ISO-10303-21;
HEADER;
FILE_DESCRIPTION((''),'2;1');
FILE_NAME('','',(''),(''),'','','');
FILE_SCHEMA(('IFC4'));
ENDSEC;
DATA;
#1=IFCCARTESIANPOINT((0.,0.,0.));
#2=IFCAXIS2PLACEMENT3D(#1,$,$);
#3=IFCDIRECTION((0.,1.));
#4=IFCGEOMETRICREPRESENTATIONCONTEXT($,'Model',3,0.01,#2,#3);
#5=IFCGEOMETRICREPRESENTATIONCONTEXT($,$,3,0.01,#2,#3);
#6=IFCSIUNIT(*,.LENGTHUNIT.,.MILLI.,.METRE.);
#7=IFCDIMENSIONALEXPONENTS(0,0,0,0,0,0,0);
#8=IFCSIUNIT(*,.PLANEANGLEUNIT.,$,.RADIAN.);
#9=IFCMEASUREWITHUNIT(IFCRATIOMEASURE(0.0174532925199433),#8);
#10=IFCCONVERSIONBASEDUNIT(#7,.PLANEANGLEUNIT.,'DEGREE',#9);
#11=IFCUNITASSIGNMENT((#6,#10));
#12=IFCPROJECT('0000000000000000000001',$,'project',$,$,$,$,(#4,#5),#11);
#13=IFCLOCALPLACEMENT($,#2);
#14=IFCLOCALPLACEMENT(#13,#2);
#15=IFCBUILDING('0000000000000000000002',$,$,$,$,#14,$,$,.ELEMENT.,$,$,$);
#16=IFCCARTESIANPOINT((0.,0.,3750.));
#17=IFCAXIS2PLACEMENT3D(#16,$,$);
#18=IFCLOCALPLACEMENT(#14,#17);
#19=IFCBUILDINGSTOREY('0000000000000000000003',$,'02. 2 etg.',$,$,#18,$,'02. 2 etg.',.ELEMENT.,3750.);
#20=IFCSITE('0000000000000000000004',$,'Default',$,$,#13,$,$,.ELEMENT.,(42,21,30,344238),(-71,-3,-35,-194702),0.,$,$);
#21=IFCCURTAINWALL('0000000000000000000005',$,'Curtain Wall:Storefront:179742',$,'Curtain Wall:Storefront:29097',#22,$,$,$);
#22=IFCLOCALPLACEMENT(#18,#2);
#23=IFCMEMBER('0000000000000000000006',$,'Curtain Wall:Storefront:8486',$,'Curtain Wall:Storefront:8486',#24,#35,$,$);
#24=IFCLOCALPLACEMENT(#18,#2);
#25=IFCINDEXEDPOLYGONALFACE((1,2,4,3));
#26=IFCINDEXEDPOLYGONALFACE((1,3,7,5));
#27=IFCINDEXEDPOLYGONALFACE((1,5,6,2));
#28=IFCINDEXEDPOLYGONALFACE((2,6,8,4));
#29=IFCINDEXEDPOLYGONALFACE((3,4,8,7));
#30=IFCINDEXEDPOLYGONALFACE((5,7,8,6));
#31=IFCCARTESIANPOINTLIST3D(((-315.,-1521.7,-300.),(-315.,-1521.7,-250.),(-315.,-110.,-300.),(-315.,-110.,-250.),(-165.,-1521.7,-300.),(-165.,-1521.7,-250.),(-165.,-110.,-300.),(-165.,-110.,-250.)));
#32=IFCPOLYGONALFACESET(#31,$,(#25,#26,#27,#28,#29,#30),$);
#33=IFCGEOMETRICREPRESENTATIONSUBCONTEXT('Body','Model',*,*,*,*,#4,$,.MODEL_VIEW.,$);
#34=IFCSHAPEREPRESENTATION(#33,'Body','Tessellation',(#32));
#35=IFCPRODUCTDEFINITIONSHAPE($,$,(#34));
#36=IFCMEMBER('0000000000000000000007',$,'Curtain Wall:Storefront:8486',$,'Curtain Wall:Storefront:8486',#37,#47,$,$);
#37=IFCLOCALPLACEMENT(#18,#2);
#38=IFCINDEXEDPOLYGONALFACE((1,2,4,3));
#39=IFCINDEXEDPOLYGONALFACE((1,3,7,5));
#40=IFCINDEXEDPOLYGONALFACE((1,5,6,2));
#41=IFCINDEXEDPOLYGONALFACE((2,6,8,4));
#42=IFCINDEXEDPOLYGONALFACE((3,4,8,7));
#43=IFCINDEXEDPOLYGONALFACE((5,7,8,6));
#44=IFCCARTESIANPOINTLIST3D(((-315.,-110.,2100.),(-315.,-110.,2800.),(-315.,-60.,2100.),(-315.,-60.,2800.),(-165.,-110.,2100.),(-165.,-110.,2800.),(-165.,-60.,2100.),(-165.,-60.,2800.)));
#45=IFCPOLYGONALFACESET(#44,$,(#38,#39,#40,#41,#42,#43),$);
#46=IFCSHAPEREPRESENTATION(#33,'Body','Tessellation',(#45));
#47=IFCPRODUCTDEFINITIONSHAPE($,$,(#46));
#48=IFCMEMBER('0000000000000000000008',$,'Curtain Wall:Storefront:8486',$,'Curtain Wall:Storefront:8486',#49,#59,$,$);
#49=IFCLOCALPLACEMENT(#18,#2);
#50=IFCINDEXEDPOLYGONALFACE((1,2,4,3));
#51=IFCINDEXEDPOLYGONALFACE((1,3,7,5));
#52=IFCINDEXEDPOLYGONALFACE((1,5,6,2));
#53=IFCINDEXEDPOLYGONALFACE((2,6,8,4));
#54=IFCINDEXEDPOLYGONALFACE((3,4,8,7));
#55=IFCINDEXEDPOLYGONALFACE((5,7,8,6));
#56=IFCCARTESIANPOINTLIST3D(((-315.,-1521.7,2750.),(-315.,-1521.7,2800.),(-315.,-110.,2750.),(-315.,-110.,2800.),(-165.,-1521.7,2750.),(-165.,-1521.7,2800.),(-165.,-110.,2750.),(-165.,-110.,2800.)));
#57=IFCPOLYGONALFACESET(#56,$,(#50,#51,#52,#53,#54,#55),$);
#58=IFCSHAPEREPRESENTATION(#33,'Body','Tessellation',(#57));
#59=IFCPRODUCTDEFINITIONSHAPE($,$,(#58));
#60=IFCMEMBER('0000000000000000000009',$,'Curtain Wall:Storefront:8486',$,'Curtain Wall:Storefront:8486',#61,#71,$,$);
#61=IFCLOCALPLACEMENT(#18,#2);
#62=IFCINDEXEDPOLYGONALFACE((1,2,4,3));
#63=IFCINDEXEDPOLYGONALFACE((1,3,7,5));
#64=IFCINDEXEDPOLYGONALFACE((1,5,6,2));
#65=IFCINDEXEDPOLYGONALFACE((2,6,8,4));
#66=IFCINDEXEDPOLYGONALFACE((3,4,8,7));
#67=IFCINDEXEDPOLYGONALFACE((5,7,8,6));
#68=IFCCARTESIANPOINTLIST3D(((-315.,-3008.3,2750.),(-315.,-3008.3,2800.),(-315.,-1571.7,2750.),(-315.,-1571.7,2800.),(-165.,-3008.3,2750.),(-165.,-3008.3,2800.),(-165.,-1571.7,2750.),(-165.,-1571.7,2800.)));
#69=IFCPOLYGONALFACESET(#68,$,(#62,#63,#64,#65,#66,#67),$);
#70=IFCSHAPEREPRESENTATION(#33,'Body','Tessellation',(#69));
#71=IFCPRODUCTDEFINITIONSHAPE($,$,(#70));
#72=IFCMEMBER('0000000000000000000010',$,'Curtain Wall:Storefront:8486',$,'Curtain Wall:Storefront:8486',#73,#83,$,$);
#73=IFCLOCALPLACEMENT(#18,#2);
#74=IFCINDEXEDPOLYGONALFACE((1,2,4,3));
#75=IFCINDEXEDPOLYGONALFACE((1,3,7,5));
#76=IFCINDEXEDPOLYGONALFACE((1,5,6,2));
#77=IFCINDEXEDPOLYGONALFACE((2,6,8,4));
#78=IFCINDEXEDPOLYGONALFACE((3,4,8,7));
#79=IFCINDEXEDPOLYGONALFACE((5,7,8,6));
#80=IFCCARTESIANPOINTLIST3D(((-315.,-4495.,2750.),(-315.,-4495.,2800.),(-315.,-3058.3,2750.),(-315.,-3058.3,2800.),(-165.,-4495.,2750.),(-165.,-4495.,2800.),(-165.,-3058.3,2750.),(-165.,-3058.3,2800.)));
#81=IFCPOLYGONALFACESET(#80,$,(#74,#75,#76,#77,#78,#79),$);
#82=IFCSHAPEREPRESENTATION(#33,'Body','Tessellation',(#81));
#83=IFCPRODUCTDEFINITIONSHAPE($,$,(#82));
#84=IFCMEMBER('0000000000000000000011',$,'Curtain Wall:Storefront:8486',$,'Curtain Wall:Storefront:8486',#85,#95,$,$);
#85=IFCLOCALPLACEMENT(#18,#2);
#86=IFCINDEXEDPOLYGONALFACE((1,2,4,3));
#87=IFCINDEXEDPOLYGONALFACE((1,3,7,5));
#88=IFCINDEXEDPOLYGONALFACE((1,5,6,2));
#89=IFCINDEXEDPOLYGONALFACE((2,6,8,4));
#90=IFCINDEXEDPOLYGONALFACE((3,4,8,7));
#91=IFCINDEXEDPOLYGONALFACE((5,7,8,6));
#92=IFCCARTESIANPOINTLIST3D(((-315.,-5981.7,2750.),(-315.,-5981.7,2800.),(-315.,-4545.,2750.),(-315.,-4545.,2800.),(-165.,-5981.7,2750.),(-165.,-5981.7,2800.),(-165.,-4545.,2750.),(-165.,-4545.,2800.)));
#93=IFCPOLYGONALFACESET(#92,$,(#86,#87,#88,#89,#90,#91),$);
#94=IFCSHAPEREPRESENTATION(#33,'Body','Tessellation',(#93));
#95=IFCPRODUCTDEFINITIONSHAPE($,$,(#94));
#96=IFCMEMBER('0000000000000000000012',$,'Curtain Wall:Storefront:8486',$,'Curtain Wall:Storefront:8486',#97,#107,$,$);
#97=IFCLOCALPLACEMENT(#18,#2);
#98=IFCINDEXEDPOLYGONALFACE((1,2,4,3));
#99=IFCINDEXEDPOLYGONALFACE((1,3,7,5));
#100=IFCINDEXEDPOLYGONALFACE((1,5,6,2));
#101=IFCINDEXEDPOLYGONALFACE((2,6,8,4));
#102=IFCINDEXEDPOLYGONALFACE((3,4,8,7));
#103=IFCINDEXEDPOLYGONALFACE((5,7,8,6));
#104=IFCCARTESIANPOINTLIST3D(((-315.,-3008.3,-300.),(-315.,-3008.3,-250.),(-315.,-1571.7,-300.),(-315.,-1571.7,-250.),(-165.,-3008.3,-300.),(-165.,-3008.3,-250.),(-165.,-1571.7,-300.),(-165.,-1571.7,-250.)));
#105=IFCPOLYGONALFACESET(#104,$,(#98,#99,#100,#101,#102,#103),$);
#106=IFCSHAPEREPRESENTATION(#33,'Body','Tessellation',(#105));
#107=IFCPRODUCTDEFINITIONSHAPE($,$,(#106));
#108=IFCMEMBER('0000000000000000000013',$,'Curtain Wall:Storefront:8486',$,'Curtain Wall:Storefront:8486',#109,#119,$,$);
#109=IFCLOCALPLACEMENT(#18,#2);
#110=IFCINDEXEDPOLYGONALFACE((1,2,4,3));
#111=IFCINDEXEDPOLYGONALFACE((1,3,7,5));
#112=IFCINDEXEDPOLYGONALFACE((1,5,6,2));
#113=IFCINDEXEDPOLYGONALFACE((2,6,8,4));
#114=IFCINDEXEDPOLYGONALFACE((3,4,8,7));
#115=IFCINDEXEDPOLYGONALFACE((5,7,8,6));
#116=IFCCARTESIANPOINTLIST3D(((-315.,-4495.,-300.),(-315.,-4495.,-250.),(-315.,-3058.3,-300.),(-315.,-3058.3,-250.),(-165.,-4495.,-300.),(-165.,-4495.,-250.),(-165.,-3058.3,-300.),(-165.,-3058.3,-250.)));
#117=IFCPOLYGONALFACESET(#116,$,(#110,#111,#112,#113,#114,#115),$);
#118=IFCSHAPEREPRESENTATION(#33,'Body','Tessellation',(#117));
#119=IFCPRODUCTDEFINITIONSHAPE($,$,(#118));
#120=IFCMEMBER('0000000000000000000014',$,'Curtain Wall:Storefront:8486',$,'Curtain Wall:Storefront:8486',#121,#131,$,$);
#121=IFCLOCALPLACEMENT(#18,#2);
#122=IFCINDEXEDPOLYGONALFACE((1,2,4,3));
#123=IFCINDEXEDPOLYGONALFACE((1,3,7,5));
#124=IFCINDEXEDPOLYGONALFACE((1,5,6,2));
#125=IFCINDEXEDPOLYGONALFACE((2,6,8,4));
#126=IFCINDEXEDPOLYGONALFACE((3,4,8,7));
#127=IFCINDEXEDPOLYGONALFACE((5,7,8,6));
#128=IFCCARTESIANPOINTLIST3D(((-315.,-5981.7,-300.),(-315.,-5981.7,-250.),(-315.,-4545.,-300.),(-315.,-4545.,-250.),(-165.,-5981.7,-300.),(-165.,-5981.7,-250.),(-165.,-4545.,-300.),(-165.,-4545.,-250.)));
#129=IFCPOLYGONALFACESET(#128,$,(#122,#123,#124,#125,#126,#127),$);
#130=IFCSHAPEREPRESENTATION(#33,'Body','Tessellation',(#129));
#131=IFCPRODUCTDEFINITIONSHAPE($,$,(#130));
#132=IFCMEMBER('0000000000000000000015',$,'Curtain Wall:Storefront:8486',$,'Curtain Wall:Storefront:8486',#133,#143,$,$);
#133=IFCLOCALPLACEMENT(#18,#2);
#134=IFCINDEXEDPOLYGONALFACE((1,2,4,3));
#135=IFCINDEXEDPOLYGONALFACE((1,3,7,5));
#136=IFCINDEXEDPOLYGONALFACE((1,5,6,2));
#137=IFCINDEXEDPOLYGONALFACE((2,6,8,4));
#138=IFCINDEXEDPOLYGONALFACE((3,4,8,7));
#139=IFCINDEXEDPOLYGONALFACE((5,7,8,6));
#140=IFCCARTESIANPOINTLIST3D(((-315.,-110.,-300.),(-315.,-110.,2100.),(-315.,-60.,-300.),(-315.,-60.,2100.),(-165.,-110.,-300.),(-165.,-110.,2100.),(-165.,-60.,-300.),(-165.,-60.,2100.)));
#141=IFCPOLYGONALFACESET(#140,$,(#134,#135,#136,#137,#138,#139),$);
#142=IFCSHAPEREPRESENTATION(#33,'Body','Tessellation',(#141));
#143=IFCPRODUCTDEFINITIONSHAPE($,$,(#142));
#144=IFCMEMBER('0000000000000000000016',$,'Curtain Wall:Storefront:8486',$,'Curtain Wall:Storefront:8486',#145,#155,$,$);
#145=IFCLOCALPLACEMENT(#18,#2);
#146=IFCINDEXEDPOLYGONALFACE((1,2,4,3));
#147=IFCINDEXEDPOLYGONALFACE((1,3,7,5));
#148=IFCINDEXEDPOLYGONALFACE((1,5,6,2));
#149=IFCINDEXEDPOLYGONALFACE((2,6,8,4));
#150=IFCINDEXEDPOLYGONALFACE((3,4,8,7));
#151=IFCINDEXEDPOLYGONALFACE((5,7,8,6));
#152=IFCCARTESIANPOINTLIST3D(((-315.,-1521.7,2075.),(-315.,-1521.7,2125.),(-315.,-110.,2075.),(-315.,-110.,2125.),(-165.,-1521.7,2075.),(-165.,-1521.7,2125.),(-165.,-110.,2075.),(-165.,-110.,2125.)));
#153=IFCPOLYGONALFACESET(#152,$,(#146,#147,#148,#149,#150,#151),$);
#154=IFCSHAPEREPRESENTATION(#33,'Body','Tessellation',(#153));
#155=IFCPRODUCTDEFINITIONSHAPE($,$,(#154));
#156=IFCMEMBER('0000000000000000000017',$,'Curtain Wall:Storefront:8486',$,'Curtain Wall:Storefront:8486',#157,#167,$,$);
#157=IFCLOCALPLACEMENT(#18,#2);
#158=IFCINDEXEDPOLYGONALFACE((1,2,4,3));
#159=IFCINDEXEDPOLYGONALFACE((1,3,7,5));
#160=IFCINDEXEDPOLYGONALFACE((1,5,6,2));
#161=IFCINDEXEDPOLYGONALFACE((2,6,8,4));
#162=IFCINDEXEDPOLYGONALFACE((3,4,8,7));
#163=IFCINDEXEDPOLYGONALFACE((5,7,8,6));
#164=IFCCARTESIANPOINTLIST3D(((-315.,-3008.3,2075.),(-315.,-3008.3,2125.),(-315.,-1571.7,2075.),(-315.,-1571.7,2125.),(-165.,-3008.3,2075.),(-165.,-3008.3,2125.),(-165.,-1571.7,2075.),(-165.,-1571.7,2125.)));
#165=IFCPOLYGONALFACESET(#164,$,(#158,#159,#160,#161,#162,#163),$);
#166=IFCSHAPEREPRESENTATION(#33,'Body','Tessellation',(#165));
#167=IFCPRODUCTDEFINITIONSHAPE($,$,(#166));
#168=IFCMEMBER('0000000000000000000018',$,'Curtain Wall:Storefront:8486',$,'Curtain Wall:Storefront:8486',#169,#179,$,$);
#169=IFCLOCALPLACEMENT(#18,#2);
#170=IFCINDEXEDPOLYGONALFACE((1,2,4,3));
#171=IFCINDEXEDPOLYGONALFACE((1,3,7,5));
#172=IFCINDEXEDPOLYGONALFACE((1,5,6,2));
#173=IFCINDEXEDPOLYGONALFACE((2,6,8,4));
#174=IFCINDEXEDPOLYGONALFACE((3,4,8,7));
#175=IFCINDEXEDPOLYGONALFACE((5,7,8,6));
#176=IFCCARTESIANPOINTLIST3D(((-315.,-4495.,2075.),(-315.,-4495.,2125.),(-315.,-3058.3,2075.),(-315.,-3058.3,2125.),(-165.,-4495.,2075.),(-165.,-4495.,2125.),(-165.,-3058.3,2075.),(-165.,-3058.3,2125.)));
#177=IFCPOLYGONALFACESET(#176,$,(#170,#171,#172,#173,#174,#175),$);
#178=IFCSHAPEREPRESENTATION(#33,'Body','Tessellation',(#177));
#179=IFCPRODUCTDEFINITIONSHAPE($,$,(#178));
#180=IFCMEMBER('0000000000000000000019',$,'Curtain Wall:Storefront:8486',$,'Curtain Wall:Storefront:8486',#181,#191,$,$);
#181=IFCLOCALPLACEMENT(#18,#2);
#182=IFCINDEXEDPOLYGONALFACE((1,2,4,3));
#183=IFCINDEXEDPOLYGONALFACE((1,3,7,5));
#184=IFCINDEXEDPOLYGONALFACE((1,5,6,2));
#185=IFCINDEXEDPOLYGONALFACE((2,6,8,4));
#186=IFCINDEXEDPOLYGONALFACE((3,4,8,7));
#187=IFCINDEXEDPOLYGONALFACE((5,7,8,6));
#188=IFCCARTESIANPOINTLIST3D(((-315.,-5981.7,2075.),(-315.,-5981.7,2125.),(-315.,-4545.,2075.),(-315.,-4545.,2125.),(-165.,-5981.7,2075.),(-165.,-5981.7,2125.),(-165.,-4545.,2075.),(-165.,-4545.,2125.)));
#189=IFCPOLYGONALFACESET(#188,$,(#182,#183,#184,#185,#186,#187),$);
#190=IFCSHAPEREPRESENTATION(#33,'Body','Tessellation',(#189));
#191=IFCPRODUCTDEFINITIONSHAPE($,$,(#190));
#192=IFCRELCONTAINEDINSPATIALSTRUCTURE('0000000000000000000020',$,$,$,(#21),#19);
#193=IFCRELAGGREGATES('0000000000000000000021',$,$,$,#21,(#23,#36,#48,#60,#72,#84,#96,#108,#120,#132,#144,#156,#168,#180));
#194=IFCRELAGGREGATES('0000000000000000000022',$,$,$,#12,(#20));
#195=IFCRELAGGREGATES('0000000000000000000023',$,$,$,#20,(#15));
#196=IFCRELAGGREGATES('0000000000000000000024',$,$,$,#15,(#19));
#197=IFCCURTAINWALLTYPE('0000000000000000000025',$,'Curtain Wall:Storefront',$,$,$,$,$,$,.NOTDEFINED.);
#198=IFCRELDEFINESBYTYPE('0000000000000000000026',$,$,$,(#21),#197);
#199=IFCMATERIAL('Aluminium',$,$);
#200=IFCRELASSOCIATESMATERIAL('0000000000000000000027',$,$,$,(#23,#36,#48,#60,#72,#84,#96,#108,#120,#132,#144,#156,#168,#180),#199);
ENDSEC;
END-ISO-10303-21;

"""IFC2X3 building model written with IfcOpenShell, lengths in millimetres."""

from ifc_helpers import new_model, entity, si_unit, converted_unit, direction, frame, frame_2d, origin, origin_2d_with_axis, place, context, subcontext, project, spatial, rectangle, extrude, material, type_object, element, aggregate, save


model = new_model("IFC2X3")

# Units and contexts
model_context = context("Model", 3, precision=0.01, world=origin(), true_north=direction((0.0, 1.0)))
context_of_model = context(None, 3, precision=0.01, world=origin(), true_north=direction((0.0, 1.0)))
body_context = subcontext(model_context, "Body", "Model", "MODEL_VIEW")
ifc_project = project(units=[si_unit("LENGTHUNIT", "METRE", prefix="MILLI"), converted_unit("PLANEANGLEUNIT", "DEGREE", entity("IfcRatioMeasure", 0.0174532925199433), si_unit("PLANEANGLEUNIT", "RADIAN"), dimensions=[0, 0, 0, 0, 0, 0, 0])], contexts=[model_context, context_of_model])

# Site, building, storey
site_placement = place(None, origin())
site = spatial("IfcSite", under=ifc_project, at=site_placement, Name="Default", CompositionType="ELEMENT", RefLatitude=(42, 21, 30, 344238), RefLongitude=(-71, -3, -35, -194702), RefElevation=0.0)
building_placement = place(site_placement, origin())
building = spatial("IfcBuilding", under=site, at=building_placement, CompositionType="ELEMENT")
storey_placement = place(building_placement, frame((0.0, 0.0, 3750.0)))
storey = spatial("IfcBuildingStorey", under=building, at=storey_placement, Name="02. 2 etg.", LongName="02. 2 etg.", CompositionType="ELEMENT", Elevation=3750.0)

# Curtain wall, members
curtain_wall_type = type_object("IfcCurtainWallType", Name="Curtain Wall:Storefront", PredefinedType="NOTDEFINED")
curtain_wall_placement = place(storey_placement, frame((0.0, 0.0, -3750.0)))
curtain_wall = element("IfcCurtainWall", 1, at=curtain_wall_placement, inside=storey, type_object=curtain_wall_type, Name="Curtain Wall:Storefront:179742", ObjectType="Curtain Wall:Storefront:29097")
ifc_material_1 = material(Name="Aluminium")
member_1_placement = place(curtain_wall_placement, frame((-315.0, -1521.7, 3450.0)))
member_1 = element("IfcMember", 2, at=member_1_placement, material=ifc_material_1, Name="Curtain Wall:Storefront:8486", ObjectType="Curtain Wall:Storefront:8486", context=body_context, shape_type="SweptSolid", body=[
    extrude(rectangle(XDim=1411.7, YDim=150.0, at=origin_2d_with_axis()), frame((75.0, 705.8, 0.0), z_axis=(0.0, 0.0, 1.0), x_axis=(0.0, -1.0, 0.0)), (0.0, 0.0, 1.0), 50.0),
])
member_2_placement = place(curtain_wall_placement, frame((-315.0, -110.0, 5850.0)))
member_2 = element("IfcMember", 3, at=member_2_placement, material=ifc_material_1, Name="Curtain Wall:Storefront:8486", ObjectType="Curtain Wall:Storefront:8486", context=body_context, shape_type="SweptSolid", body=[
    extrude(rectangle(XDim=50.0, YDim=150.0, at=frame_2d((0.0, 0.0), x_axis=(1.0, 0.0))), frame((75.0, 25.0, 0.0), z_axis=(0.0, 0.0, 1.0), x_axis=(0.0, -1.0, 0.0)), (0.0, 0.0, 1.0), 700.0),
])
member_3_placement = place(curtain_wall_placement, frame((-315.0, -1521.7, 6500.0)))
member_3 = element("IfcMember", 4, at=member_3_placement, material=ifc_material_1, Name="Curtain Wall:Storefront:8486", ObjectType="Curtain Wall:Storefront:8486", context=body_context, shape_type="SweptSolid", body=[
    extrude(rectangle(XDim=1411.7, YDim=150.0, at=origin_2d_with_axis()), frame((75.0, 705.8, 0.0), z_axis=(0.0, 0.0, 1.0), x_axis=(0.0, 1.0, 0.0)), (0.0, 0.0, 1.0), 50.0),
])
member_4_placement = place(curtain_wall_placement, frame((-315.0, -3008.3, 6500.0)))
member_4 = element("IfcMember", 5, at=member_4_placement, material=ifc_material_1, Name="Curtain Wall:Storefront:8486", ObjectType="Curtain Wall:Storefront:8486", context=body_context, shape_type="SweptSolid", body=[
    extrude(rectangle(XDim=1436.7, YDim=150.0, at=frame_2d((0.0, 0.0), x_axis=(1.0, 0.0))), frame((75.0, 718.3, 0.0), z_axis=(0.0, 0.0, 1.0), x_axis=(0.0, 1.0, 0.0)), (0.0, 0.0, 1.0), 50.0),
])
member_5_placement = place(curtain_wall_placement, frame((-315.0, -4495.0, 6500.0)))
member_5 = element("IfcMember", 6, at=member_5_placement, material=ifc_material_1, Name="Curtain Wall:Storefront:8486", ObjectType="Curtain Wall:Storefront:8486", context=body_context, shape_type="SweptSolid", body=[
    extrude(rectangle(XDim=1436.7, YDim=150.0, at=frame_2d((0.0, 0.0), x_axis=(1.0, 0.0))), frame((75.0, 718.3, 0.0), z_axis=(0.0, 0.0, 1.0), x_axis=(0.0, 1.0, 0.0)), (0.0, 0.0, 1.0), 50.0),
])
member_6_placement = place(curtain_wall_placement, frame((-315.0, -5981.7, 6500.0)))
member_6 = element("IfcMember", 7, at=member_6_placement, material=ifc_material_1, Name="Curtain Wall:Storefront:8486", ObjectType="Curtain Wall:Storefront:8486", context=body_context, shape_type="SweptSolid", body=[
    extrude(rectangle(XDim=1436.7, YDim=150.0, at=frame_2d((0.0, 0.0), x_axis=(1.0, 0.0))), frame((75.0, 718.3, 0.0), z_axis=(0.0, 0.0, 1.0), x_axis=(0.0, 1.0, 0.0)), (0.0, 0.0, 1.0), 50.0),
])
member_7_placement = place(curtain_wall_placement, frame((-315.0, -3008.3, 3450.0)))
member_7 = element("IfcMember", 8, at=member_7_placement, material=ifc_material_1, Name="Curtain Wall:Storefront:8486", ObjectType="Curtain Wall:Storefront:8486", context=body_context, shape_type="SweptSolid", body=[
    extrude(rectangle(XDim=1436.7, YDim=150.0, at=frame_2d((0.0, 0.0), x_axis=(1.0, 0.0))), frame((75.0, 718.3, 0.0), z_axis=(0.0, 0.0, 1.0), x_axis=(0.0, -1.0, 0.0)), (0.0, 0.0, 1.0), 50.0),
])
member_8_placement = place(curtain_wall_placement, frame((-315.0, -4495.0, 3450.0)))
member_8 = element("IfcMember", 9, at=member_8_placement, material=ifc_material_1, Name="Curtain Wall:Storefront:8486", ObjectType="Curtain Wall:Storefront:8486", context=body_context, shape_type="SweptSolid", body=[
    extrude(rectangle(XDim=1436.7, YDim=150.0, at=frame_2d((0.0, 0.0), x_axis=(1.0, 0.0))), frame((75.0, 718.3, 0.0), z_axis=(0.0, 0.0, 1.0), x_axis=(0.0, -1.0, 0.0)), (0.0, 0.0, 1.0), 50.0),
])
member_9_placement = place(curtain_wall_placement, frame((-315.0, -5981.7, 3450.0)))
member_9 = element("IfcMember", 10, at=member_9_placement, material=ifc_material_1, Name="Curtain Wall:Storefront:8486", ObjectType="Curtain Wall:Storefront:8486", context=body_context, shape_type="SweptSolid", body=[
    extrude(rectangle(XDim=1436.7, YDim=150.0, at=frame_2d((0.0, 0.0), x_axis=(1.0, 0.0))), frame((75.0, 718.3, 0.0), z_axis=(0.0, 0.0, 1.0), x_axis=(0.0, -1.0, 0.0)), (0.0, 0.0, 1.0), 50.0),
])
member_10_placement = place(curtain_wall_placement, frame((-315.0, -110.0, 3450.0)))
member_10 = element("IfcMember", 11, at=member_10_placement, material=ifc_material_1, Name="Curtain Wall:Storefront:8486", ObjectType="Curtain Wall:Storefront:8486", context=body_context, shape_type="SweptSolid", body=[
    extrude(rectangle(XDim=50.0, YDim=150.0, at=frame_2d((0.0, 0.0), x_axis=(1.0, 0.0))), frame((75.0, 25.0, 0.0), z_axis=(0.0, 0.0, 1.0), x_axis=(0.0, -1.0, 0.0)), (0.0, 0.0, 1.0), 2400.0),
])
member_11_placement = place(curtain_wall_placement, frame((-315.0, -1521.7, 5825.0)))
member_11 = element("IfcMember", 12, at=member_11_placement, material=ifc_material_1, Name="Curtain Wall:Storefront:8486", ObjectType="Curtain Wall:Storefront:8486", context=body_context, shape_type="SweptSolid", body=[
    extrude(rectangle(XDim=1411.7, YDim=150.0, at=frame_2d((0.0, 0.0), x_axis=(1.0, 0.0))), frame((75.0, 705.8, 0.0), z_axis=(0.0, 0.0, 1.0), x_axis=(0.0, 1.0, 0.0)), (0.0, 0.0, 1.0), 50.0),
])
member_12_placement = place(curtain_wall_placement, frame((-315.0, -3008.3, 5825.0)))
member_12 = element("IfcMember", 13, at=member_12_placement, material=ifc_material_1, Name="Curtain Wall:Storefront:8486", ObjectType="Curtain Wall:Storefront:8486", context=body_context, shape_type="SweptSolid", body=[
    extrude(rectangle(XDim=1436.7, YDim=150.0, at=frame_2d((0.0, 0.0), x_axis=(1.0, 0.0))), frame((75.0, 718.3, 0.0), z_axis=(0.0, 0.0, 1.0), x_axis=(0.0, 1.0, 0.0)), (0.0, 0.0, 1.0), 50.0),
])
member_13_placement = place(curtain_wall_placement, frame((-315.0, -4495.0, 5825.0)))
member_13 = element("IfcMember", 14, at=member_13_placement, material=ifc_material_1, Name="Curtain Wall:Storefront:8486", ObjectType="Curtain Wall:Storefront:8486", context=body_context, shape_type="SweptSolid", body=[
    extrude(rectangle(XDim=1436.7, YDim=150.0, at=frame_2d((0.0, 0.0), x_axis=(1.0, 0.0))), frame((75.0, 718.3, 0.0), z_axis=(0.0, 0.0, 1.0), x_axis=(0.0, 1.0, 0.0)), (0.0, 0.0, 1.0), 50.0),
])
member_14_placement = place(curtain_wall_placement, frame((-315.0, -5981.7, 5825.0)))
member_14 = element("IfcMember", 15, at=member_14_placement, material=ifc_material_1, Name="Curtain Wall:Storefront:8486", ObjectType="Curtain Wall:Storefront:8486", context=body_context, shape_type="SweptSolid", body=[
    extrude(rectangle(XDim=1436.7, YDim=150.0, at=frame_2d((0.0, 0.0), x_axis=(1.0, 0.0))), frame((75.0, 718.3, 0.0), z_axis=(0.0, 0.0, 1.0), x_axis=(0.0, 1.0, 0.0)), (0.0, 0.0, 1.0), 50.0),
])
aggregate(curtain_wall, [member_1, member_2, member_3, member_4, member_5, member_6, member_7, member_8, member_9, member_10, member_11, member_12, member_13, member_14])

save(model, "model.ifc")
